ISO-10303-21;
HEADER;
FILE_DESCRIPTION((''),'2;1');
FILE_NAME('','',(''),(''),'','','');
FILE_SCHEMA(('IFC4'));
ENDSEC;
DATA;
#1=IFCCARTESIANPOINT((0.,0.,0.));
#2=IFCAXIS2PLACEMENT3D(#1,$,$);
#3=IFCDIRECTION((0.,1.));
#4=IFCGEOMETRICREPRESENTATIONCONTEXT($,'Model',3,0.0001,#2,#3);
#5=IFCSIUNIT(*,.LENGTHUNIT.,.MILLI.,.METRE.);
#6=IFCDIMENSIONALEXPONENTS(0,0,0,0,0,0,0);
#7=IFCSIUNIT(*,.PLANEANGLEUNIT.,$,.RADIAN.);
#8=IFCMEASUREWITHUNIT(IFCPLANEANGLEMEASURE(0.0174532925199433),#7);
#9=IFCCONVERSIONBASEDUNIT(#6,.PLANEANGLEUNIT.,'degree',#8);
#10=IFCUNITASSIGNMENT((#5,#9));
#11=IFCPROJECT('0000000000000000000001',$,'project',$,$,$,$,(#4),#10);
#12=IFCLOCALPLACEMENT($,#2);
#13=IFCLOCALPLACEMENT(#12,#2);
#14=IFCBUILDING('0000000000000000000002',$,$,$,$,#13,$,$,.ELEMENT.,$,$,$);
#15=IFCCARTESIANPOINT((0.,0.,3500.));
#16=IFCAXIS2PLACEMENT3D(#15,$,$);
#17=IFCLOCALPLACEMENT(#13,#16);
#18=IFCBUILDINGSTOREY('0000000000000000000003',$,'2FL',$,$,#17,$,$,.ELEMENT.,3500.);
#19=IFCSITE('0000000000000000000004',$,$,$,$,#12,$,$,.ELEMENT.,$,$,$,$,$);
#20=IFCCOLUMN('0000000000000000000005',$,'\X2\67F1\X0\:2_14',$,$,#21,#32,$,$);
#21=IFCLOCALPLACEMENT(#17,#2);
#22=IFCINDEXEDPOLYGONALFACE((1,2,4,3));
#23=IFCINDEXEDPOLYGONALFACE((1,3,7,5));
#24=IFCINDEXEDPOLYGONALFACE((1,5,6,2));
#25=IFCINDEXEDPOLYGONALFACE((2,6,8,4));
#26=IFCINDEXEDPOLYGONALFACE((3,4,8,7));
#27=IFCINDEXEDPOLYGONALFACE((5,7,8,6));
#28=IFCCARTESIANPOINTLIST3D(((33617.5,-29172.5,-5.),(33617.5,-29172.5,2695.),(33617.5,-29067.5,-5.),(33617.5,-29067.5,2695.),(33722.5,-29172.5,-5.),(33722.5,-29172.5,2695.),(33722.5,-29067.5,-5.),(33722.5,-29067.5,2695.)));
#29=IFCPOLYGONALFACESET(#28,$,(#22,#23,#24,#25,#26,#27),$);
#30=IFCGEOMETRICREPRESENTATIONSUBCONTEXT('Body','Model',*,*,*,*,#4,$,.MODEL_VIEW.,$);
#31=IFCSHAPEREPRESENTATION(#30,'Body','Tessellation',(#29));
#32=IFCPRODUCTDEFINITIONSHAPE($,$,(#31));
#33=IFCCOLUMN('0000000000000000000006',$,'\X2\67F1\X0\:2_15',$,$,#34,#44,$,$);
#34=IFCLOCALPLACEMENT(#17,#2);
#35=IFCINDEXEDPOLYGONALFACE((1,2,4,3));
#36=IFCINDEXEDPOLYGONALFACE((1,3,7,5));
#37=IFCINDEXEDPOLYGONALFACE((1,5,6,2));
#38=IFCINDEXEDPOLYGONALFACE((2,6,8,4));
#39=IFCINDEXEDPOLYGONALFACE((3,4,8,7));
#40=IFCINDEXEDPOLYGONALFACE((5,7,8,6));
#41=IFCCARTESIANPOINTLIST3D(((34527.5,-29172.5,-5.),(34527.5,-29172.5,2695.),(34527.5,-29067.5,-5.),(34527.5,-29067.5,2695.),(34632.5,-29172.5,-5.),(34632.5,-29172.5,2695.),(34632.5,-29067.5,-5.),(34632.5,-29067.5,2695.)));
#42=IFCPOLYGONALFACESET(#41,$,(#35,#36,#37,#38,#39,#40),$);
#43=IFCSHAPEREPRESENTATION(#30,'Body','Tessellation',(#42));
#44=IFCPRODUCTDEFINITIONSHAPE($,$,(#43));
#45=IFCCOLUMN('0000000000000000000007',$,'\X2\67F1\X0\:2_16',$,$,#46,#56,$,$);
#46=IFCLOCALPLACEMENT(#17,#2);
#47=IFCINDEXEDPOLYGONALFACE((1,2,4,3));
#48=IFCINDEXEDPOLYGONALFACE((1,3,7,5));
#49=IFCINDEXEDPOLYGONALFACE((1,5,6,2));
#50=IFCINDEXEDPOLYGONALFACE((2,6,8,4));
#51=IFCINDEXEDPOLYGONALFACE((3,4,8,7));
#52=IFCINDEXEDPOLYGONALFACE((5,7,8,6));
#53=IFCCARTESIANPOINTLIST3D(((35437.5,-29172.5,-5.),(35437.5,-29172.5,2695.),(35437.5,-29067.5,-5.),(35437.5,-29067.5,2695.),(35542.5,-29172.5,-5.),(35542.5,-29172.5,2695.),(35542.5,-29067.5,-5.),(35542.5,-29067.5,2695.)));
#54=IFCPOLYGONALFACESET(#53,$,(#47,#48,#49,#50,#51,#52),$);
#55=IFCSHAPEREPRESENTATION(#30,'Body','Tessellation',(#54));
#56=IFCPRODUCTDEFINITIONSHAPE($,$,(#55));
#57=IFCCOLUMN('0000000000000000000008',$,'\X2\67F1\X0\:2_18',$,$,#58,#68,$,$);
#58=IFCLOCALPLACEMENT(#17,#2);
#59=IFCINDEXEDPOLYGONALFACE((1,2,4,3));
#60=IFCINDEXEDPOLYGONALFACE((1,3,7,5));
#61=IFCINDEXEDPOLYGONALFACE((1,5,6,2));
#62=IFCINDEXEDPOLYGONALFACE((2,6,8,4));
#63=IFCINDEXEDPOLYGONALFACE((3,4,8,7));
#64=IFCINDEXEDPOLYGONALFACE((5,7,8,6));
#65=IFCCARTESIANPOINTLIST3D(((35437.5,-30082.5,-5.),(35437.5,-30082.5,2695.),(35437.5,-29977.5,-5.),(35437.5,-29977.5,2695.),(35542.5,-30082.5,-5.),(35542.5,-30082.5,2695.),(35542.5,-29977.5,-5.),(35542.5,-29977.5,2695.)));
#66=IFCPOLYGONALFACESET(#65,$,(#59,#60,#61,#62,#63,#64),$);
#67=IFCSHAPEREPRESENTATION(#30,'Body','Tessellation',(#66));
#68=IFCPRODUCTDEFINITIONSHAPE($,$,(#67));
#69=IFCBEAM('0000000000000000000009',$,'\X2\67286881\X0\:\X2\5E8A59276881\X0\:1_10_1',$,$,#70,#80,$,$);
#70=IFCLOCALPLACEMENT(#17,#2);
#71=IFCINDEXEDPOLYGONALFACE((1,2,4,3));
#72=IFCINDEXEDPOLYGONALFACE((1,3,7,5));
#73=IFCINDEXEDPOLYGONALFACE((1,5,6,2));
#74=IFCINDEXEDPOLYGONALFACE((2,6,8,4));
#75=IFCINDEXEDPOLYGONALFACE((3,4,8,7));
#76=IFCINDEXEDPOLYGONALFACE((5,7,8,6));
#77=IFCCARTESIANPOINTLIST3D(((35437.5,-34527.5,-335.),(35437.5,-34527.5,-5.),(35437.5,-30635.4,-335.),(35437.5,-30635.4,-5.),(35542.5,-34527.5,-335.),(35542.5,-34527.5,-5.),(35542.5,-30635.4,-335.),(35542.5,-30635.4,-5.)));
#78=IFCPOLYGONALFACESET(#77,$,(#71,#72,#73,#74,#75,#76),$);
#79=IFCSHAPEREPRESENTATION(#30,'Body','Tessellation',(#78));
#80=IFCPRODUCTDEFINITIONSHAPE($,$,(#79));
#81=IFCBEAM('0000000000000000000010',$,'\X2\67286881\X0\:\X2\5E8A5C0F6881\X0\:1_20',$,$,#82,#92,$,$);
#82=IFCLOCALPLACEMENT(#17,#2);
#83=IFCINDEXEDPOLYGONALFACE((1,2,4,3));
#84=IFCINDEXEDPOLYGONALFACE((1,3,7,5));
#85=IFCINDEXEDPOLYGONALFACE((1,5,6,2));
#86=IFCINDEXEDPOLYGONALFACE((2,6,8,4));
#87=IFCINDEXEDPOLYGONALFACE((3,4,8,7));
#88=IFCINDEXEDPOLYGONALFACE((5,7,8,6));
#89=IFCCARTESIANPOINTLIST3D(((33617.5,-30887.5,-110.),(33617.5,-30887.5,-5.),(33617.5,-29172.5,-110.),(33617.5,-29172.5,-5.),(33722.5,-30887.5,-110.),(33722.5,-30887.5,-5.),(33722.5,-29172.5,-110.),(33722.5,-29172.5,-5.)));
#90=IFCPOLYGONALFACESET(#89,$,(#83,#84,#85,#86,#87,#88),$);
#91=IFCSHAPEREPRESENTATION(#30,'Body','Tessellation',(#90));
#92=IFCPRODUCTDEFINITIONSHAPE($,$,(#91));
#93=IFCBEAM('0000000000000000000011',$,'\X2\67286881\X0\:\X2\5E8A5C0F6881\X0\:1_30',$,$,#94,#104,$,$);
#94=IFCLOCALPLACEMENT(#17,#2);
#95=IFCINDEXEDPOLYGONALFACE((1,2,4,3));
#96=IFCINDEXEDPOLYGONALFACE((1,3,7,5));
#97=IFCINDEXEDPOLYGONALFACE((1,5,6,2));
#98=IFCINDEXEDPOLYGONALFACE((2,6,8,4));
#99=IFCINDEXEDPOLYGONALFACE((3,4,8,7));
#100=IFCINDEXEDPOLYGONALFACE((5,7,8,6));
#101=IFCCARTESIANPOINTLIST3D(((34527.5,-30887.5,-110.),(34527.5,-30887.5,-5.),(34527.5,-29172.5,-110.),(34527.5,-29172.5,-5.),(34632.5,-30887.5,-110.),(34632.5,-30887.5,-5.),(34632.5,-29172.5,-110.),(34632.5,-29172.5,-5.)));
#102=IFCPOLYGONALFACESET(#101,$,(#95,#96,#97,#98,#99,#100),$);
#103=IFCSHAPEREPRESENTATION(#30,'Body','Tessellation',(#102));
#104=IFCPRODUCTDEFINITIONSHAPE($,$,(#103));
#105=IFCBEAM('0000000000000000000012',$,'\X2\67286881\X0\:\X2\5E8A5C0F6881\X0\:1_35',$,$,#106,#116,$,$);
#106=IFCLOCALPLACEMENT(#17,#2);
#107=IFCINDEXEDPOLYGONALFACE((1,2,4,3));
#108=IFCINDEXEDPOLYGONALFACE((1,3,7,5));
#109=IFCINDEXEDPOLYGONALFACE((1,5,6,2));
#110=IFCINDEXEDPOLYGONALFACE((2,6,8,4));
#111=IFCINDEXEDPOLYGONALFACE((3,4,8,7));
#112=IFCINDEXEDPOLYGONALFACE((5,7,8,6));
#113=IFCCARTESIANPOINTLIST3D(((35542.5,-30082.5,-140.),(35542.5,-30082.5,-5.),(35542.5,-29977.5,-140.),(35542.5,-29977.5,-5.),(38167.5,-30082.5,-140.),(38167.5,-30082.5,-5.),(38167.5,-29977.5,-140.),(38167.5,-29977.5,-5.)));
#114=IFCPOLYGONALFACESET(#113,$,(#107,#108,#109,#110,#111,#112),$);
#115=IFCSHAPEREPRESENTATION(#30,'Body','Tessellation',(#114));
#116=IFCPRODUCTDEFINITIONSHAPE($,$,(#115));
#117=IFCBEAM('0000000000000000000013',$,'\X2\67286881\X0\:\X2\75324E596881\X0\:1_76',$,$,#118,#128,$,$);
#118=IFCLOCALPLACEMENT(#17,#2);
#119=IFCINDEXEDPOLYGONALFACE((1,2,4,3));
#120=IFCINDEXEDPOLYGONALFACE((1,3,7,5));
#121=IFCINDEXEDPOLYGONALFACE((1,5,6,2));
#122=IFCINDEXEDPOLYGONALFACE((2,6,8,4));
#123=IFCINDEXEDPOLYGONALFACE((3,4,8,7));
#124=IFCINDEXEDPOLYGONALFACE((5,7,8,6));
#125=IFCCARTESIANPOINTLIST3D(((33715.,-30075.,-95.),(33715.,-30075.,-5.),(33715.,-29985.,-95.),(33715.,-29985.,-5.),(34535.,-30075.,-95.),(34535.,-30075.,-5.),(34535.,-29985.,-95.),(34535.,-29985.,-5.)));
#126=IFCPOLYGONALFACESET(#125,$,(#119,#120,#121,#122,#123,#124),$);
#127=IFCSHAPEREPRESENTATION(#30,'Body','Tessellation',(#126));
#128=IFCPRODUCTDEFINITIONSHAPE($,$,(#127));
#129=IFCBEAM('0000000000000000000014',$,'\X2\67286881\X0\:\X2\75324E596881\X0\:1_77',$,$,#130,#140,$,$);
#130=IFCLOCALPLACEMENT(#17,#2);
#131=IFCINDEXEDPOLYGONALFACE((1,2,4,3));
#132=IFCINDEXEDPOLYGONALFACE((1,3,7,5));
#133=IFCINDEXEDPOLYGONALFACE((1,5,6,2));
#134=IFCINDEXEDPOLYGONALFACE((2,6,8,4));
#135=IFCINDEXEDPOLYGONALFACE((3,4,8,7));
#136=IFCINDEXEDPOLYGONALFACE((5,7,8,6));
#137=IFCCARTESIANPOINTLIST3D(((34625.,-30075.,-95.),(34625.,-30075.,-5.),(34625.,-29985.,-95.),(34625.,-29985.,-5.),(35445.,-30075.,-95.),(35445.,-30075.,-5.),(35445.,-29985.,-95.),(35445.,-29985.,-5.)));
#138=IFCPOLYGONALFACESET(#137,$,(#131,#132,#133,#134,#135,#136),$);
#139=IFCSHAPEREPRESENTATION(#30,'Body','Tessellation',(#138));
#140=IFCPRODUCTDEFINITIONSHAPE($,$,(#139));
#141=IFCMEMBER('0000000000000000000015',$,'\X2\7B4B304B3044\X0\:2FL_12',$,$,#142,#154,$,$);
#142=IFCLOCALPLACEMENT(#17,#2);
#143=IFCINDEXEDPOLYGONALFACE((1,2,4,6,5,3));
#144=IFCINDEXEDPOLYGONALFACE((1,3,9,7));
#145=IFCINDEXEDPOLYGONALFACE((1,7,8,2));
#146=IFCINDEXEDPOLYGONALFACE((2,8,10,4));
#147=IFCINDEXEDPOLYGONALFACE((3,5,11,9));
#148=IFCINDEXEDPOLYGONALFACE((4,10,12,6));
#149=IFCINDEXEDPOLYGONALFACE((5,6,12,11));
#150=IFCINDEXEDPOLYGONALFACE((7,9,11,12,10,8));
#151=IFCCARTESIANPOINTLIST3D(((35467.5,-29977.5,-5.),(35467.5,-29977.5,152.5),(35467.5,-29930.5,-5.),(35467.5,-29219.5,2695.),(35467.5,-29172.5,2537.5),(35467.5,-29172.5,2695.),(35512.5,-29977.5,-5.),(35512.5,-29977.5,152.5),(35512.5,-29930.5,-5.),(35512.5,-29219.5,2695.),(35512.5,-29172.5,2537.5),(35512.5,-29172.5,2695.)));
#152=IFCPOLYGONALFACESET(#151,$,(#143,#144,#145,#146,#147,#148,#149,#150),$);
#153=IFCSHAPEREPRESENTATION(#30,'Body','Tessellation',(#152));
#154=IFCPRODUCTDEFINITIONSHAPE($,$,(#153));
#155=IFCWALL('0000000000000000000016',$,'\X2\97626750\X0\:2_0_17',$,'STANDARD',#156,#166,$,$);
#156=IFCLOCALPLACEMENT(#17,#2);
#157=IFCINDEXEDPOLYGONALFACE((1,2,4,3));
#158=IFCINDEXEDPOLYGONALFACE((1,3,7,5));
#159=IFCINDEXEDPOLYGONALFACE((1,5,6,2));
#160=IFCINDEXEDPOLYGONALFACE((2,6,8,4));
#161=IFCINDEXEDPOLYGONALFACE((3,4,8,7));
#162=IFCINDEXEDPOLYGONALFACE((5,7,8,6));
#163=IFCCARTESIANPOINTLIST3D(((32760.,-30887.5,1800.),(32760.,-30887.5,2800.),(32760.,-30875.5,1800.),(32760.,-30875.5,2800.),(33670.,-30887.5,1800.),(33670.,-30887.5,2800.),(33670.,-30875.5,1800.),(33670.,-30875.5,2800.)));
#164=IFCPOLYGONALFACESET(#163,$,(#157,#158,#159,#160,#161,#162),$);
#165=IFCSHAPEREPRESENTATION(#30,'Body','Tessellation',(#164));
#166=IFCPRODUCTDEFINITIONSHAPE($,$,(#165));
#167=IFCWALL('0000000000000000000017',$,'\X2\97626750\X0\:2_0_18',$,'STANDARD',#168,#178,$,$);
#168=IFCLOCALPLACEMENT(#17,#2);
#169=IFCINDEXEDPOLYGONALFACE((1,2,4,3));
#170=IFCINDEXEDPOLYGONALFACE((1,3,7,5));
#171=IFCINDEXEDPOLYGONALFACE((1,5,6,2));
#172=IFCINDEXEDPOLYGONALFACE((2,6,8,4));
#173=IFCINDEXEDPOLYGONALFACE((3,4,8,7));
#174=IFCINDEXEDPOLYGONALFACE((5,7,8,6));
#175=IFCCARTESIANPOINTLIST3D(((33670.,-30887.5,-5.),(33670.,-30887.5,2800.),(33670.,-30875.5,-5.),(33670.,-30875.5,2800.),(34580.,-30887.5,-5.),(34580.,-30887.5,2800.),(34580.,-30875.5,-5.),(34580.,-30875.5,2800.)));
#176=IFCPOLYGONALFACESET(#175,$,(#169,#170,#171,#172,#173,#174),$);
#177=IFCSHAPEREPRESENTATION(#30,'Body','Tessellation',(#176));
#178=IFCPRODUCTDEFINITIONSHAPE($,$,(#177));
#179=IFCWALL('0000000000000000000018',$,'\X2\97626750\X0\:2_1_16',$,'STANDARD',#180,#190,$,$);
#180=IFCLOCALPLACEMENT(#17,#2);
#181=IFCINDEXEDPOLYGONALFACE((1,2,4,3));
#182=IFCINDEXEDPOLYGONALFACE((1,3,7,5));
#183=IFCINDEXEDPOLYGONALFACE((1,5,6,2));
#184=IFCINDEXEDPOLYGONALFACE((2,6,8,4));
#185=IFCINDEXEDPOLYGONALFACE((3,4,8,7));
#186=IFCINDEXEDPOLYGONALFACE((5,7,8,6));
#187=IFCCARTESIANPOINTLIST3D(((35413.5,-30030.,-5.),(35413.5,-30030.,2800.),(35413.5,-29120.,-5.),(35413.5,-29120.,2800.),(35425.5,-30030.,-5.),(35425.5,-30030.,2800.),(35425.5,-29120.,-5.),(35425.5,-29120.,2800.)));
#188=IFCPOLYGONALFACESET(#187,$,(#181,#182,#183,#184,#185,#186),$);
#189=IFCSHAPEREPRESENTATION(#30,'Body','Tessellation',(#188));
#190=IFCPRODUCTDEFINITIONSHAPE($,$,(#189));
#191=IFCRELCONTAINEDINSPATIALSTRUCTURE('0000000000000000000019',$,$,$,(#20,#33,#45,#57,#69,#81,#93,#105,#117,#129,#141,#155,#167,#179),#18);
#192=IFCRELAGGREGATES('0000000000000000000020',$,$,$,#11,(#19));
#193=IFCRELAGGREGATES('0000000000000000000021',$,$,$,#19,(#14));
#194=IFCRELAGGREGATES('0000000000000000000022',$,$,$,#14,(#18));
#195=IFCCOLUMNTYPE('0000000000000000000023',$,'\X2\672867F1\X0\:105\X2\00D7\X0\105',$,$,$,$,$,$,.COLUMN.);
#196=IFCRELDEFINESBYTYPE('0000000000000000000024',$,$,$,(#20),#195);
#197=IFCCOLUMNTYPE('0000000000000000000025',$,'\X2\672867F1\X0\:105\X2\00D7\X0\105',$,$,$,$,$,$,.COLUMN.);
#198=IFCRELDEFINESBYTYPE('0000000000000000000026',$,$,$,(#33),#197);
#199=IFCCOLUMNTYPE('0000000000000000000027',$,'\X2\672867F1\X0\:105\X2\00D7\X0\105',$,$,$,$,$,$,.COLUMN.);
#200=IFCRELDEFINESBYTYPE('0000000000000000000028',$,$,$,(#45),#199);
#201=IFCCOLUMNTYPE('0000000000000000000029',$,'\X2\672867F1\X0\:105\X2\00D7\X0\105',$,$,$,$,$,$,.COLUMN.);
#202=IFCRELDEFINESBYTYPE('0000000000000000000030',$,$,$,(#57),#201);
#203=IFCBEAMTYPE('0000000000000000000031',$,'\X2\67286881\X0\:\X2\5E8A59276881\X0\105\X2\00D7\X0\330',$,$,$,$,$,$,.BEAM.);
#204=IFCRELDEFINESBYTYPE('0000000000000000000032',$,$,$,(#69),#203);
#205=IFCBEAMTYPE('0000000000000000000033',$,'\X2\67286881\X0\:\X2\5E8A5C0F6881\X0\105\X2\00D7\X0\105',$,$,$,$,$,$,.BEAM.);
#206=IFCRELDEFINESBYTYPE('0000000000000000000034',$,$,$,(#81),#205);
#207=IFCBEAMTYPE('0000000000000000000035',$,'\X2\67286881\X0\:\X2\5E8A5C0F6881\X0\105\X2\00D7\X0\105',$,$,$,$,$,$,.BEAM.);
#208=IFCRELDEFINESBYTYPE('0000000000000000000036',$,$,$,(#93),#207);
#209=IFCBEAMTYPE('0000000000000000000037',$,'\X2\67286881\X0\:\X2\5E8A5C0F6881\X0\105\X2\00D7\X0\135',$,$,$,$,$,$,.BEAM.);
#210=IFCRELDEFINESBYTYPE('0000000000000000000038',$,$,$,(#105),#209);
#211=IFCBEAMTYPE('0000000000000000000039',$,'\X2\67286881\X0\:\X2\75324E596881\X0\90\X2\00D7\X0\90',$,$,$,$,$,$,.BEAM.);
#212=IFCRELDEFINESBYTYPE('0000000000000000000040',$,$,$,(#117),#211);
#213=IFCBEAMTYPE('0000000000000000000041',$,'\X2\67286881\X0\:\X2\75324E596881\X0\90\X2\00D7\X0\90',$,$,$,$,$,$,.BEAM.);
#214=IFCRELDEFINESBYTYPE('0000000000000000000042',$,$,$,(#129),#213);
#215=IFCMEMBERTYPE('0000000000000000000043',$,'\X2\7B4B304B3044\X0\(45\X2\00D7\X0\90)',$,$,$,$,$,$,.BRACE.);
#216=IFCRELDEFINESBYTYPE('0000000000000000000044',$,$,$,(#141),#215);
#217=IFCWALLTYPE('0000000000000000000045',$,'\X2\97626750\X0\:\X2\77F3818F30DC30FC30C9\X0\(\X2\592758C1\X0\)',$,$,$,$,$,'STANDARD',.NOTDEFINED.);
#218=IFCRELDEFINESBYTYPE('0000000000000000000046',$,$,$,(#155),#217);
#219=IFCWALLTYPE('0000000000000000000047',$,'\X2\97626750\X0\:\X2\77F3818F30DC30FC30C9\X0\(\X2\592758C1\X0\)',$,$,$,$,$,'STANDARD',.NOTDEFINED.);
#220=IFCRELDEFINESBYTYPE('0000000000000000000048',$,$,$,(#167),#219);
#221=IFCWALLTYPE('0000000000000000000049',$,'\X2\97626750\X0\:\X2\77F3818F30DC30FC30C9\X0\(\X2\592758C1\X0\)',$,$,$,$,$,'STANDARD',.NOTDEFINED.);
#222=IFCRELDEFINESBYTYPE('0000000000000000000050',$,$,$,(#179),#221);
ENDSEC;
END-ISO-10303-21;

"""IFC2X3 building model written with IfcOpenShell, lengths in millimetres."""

from ifc_helpers import new_model, entity, si_unit, converted_unit, direction, frame, origin, origin_with_axes, origin_2d, place, context, subcontext, project, spatial, polyline, rectangle, outline, extrude, type_object, element, save


model = new_model("IFC2X3")

# Units and contexts
model_context = context("Model", 3, precision=0.0001, world=origin(), true_north=direction((0.0, 1.0)))
body_context = subcontext(model_context, "Body", "Model", "MODEL_VIEW")
ifc_project = project(units=[si_unit("LENGTHUNIT", "METRE", prefix="MILLI"), converted_unit("PLANEANGLEUNIT", "degree", entity("IfcPlaneAngleMeasure", 0.0174532925199433), si_unit("PLANEANGLEUNIT", "RADIAN"), dimensions=[0, 0, 0, 0, 0, 0, 0])], contexts=[model_context])

# Site, building, storey
site_placement = place(None, origin())
site = spatial("IfcSite", under=ifc_project, at=site_placement, CompositionType="ELEMENT")
building_placement = place(site_placement, origin())
building = spatial("IfcBuilding", under=site, at=building_placement, CompositionType="ELEMENT")
storey_placement = place(building_placement, frame((0.0, 0.0, 3500.0)))
storey = spatial("IfcBuildingStorey", under=building, at=storey_placement, Name="2FL", CompositionType="ELEMENT", Elevation=3500.0)

# Columns
column_type_1 = type_object("IfcColumnType", Name="木柱:105×105", PredefinedType="COLUMN")
column_1_placement = place(storey_placement, frame((33670.0, -29120.0, -5.0)))
element("IfcColumn", 1, at=column_1_placement, inside=storey, type_object=column_type_1, Name="柱:2_14", context=body_context, shape_type="SweptSolid", body=[
    extrude(rectangle(XDim=105.0, YDim=105.0, at=origin_2d()), origin_with_axes(), (0.0, 0.0, 1.0), 2700.0),
])
column_type_2 = type_object("IfcColumnType", Name="木柱:105×105", PredefinedType="COLUMN")
column_2_placement = place(storey_placement, frame((34580.0, -29120.0, -5.0)))
element("IfcColumn", 2, at=column_2_placement, inside=storey, type_object=column_type_2, Name="柱:2_15", context=body_context, shape_type="SweptSolid", body=[
    extrude(rectangle(XDim=105.0, YDim=105.0, at=origin_2d()), origin_with_axes(), (0.0, 0.0, 1.0), 2700.0),
])
column_type_3 = type_object("IfcColumnType", Name="木柱:105×105", PredefinedType="COLUMN")
column_3_placement = place(storey_placement, frame((35490.0, -29120.0, -5.0)))
element("IfcColumn", 3, at=column_3_placement, inside=storey, type_object=column_type_3, Name="柱:2_16", context=body_context, shape_type="SweptSolid", body=[
    extrude(rectangle(XDim=105.0, YDim=105.0, at=origin_2d()), origin_with_axes(), (0.0, 0.0, 1.0), 2700.0),
])
column_type_4 = type_object("IfcColumnType", Name="木柱:105×105", PredefinedType="COLUMN")
column_4_placement = place(storey_placement, frame((35490.0, -30030.0, -5.0)))
element("IfcColumn", 4, at=column_4_placement, inside=storey, type_object=column_type_4, Name="柱:2_18", context=body_context, shape_type="SweptSolid", body=[
    extrude(rectangle(XDim=105.0, YDim=105.0, at=origin_2d()), origin_with_axes(), (0.0, 0.0, 1.0), 2700.0),
])

# Beams
beam_type_1 = type_object("IfcBeamType", Name="木梁:床大梁105×330", PredefinedType="BEAM")
beam_1_placement = place(storey_placement, frame((35490.0, -30635.4, -170.0), z_axis=(0.0, -1.0, 0.0), x_axis=(1.0, 0.0, 0.0)))
element("IfcBeam", 5, at=beam_1_placement, inside=storey, type_object=beam_type_1, Name="木梁:床大梁:1_10_1", context=body_context, shape_type="SweptSolid", body=[
    extrude(rectangle(XDim=105.0, YDim=330.0, at=origin_2d()), origin_with_axes(), (0.0, 0.0, 1.0), 3892.1),
])
beam_type_2 = type_object("IfcBeamType", Name="木梁:床小梁105×105", PredefinedType="BEAM")
beam_2_placement = place(storey_placement, frame((33670.0, -29172.5, -57.5), z_axis=(0.0, -1.0, 0.0), x_axis=(1.0, 0.0, 0.0)))
element("IfcBeam", 6, at=beam_2_placement, inside=storey, type_object=beam_type_2, Name="木梁:床小梁:1_20", context=body_context, shape_type="SweptSolid", body=[
    extrude(rectangle(XDim=105.0, YDim=105.0, at=origin_2d()), origin_with_axes(), (0.0, 0.0, 1.0), 1715.0),
])
beam_type_3 = type_object("IfcBeamType", Name="木梁:床小梁105×105", PredefinedType="BEAM")
beam_3_placement = place(storey_placement, frame((34580.0, -29172.5, -57.5), z_axis=(0.0, -1.0, 0.0), x_axis=(1.0, 0.0, 0.0)))
element("IfcBeam", 7, at=beam_3_placement, inside=storey, type_object=beam_type_3, Name="木梁:床小梁:1_30", context=body_context, shape_type="SweptSolid", body=[
    extrude(rectangle(XDim=105.0, YDim=105.0, at=origin_2d()), origin_with_axes(), (0.0, 0.0, 1.0), 1715.0),
])
beam_type_4 = type_object("IfcBeamType", Name="木梁:床小梁105×135", PredefinedType="BEAM")
beam_4_placement = place(storey_placement, frame((35542.5, -30030.0, -72.5), z_axis=(1.0, 0.0, 0.0), x_axis=(0.0, 1.0, 0.0)))
element("IfcBeam", 8, at=beam_4_placement, inside=storey, type_object=beam_type_4, Name="木梁:床小梁:1_35", context=body_context, shape_type="SweptSolid", body=[
    extrude(rectangle(XDim=105.0, YDim=135.0, at=origin_2d()), origin_with_axes(), (0.0, 0.0, 1.0), 2625.0),
])
beam_type_5 = type_object("IfcBeamType", Name="木梁:甲乙梁90×90", PredefinedType="BEAM")
beam_5_placement = place(storey_placement, frame((33715.0, -30030.0, -50.0), z_axis=(1.0, 0.0, 0.0), x_axis=(0.0, 1.0, 0.0)))
element("IfcBeam", 9, at=beam_5_placement, inside=storey, type_object=beam_type_5, Name="木梁:甲乙梁:1_76", context=body_context, shape_type="SweptSolid", body=[
    extrude(rectangle(XDim=90.0, YDim=90.0, at=origin_2d()), origin_with_axes(), (0.0, 0.0, 1.0), 820.0),
])
beam_type_6 = type_object("IfcBeamType", Name="木梁:甲乙梁90×90", PredefinedType="BEAM")
beam_6_placement = place(storey_placement, frame((34625.0, -30030.0, -50.0), z_axis=(1.0, 0.0, 0.0), x_axis=(0.0, 1.0, 0.0)))
element("IfcBeam", 10, at=beam_6_placement, inside=storey, type_object=beam_type_6, Name="木梁:甲乙梁:1_77", context=body_context, shape_type="SweptSolid", body=[
    extrude(rectangle(XDim=90.0, YDim=90.0, at=origin_2d()), origin_with_axes(), (0.0, 0.0, 1.0), 820.0),
])

# Member
member_type = type_object("IfcMemberType", Name="筋かい(45×90)", PredefinedType="BRACE")
member_placement = place(storey_placement, frame((35490.0, -29977.5, -5.0), z_axis=(0.0, 0.285719, 0.958313), x_axis=(0.0, -0.958313, 0.285719)))
element("IfcMember", 11, at=member_placement, inside=storey, type_object=member_type, Name="筋かい:2FL_12", context=body_context, shape_type="SweptSolid", body=[
    extrude(outline(polyline([(0.0, 0.0), (13.4, -45.0), (2666.5, -45.0), (2817.5, 0.0), (2804.0, 45.0), (150.9, 45.0), (0.0, 0.0)])), frame((0.0, -22.5, 0.0), z_axis=(0.0, 1.0, 0.0), x_axis=(0.0, 0.0, 1.0)), (0.0, 0.0, 1.0), 45.0),
])

# Walls
wall_type_1 = type_object("IfcWallType", Name="面材:石膏ボード(大壁)", ElementType="STANDARD", PredefinedType="NOTDEFINED")
wall_1_placement = place(storey_placement, frame((33215.0, -30875.5, 1800.0), z_axis=(0.0, -1.0, 0.0), x_axis=(1.0, 0.0, 0.0)))
element("IfcWall", 12, at=wall_1_placement, inside=storey, type_object=wall_type_1, Name="面材:2_0_17", ObjectType="STANDARD", context=body_context, shape_type="SweptSolid", body=[
    extrude(outline(polyline([(-455.0, 0.0, 0.0), (-455.0, 1000.0, 0.0), (455.0, 1000.0, 0.0), (455.0, 0.0, 0.0), (-455.0, 0.0, 0.0)])), origin_with_axes(), (0.0, 0.0, 1.0), 12.0),
])
wall_type_2 = type_object("IfcWallType", Name="面材:石膏ボード(大壁)", ElementType="STANDARD", PredefinedType="NOTDEFINED")
wall_2_placement = place(storey_placement, frame((34125.0, -30875.5, -5.0), z_axis=(0.0, -1.0, 0.0), x_axis=(1.0, 0.0, 0.0)))
element("IfcWall", 13, at=wall_2_placement, inside=storey, type_object=wall_type_2, Name="面材:2_0_18", ObjectType="STANDARD", context=body_context, shape_type="SweptSolid", body=[
    extrude(outline(polyline([(455.0, 0.0, 0.0), (-455.0, 0.0, 0.0), (-455.0, 2805.0, 0.0), (455.0, 2805.0, 0.0), (455.0, 0.0, 0.0)])), origin_with_axes(), (0.0, 0.0, 1.0), 12.0),
])
wall_type_3 = type_object("IfcWallType", Name="面材:石膏ボード(大壁)", ElementType="STANDARD", PredefinedType="NOTDEFINED")
wall_3_placement = place(storey_placement, frame((35425.5, -29575.0, -5.0), z_axis=(-1.0, 0.0, 0.0), x_axis=(0.0, -1.0, 0.0)))
element("IfcWall", 14, at=wall_3_placement, inside=storey, type_object=wall_type_3, Name="面材:2_1_16", ObjectType="STANDARD", context=body_context, shape_type="SweptSolid", body=[
    extrude(outline(polyline([(455.0, 0.0, 0.0), (-455.0, 0.0, 0.0), (-455.0, 2805.0, 0.0), (455.0, 2805.0, 0.0), (455.0, 0.0, 0.0)])), origin_with_axes(), (0.0, 0.0, 1.0), 12.0),
])

save(model, "model.ifc")
